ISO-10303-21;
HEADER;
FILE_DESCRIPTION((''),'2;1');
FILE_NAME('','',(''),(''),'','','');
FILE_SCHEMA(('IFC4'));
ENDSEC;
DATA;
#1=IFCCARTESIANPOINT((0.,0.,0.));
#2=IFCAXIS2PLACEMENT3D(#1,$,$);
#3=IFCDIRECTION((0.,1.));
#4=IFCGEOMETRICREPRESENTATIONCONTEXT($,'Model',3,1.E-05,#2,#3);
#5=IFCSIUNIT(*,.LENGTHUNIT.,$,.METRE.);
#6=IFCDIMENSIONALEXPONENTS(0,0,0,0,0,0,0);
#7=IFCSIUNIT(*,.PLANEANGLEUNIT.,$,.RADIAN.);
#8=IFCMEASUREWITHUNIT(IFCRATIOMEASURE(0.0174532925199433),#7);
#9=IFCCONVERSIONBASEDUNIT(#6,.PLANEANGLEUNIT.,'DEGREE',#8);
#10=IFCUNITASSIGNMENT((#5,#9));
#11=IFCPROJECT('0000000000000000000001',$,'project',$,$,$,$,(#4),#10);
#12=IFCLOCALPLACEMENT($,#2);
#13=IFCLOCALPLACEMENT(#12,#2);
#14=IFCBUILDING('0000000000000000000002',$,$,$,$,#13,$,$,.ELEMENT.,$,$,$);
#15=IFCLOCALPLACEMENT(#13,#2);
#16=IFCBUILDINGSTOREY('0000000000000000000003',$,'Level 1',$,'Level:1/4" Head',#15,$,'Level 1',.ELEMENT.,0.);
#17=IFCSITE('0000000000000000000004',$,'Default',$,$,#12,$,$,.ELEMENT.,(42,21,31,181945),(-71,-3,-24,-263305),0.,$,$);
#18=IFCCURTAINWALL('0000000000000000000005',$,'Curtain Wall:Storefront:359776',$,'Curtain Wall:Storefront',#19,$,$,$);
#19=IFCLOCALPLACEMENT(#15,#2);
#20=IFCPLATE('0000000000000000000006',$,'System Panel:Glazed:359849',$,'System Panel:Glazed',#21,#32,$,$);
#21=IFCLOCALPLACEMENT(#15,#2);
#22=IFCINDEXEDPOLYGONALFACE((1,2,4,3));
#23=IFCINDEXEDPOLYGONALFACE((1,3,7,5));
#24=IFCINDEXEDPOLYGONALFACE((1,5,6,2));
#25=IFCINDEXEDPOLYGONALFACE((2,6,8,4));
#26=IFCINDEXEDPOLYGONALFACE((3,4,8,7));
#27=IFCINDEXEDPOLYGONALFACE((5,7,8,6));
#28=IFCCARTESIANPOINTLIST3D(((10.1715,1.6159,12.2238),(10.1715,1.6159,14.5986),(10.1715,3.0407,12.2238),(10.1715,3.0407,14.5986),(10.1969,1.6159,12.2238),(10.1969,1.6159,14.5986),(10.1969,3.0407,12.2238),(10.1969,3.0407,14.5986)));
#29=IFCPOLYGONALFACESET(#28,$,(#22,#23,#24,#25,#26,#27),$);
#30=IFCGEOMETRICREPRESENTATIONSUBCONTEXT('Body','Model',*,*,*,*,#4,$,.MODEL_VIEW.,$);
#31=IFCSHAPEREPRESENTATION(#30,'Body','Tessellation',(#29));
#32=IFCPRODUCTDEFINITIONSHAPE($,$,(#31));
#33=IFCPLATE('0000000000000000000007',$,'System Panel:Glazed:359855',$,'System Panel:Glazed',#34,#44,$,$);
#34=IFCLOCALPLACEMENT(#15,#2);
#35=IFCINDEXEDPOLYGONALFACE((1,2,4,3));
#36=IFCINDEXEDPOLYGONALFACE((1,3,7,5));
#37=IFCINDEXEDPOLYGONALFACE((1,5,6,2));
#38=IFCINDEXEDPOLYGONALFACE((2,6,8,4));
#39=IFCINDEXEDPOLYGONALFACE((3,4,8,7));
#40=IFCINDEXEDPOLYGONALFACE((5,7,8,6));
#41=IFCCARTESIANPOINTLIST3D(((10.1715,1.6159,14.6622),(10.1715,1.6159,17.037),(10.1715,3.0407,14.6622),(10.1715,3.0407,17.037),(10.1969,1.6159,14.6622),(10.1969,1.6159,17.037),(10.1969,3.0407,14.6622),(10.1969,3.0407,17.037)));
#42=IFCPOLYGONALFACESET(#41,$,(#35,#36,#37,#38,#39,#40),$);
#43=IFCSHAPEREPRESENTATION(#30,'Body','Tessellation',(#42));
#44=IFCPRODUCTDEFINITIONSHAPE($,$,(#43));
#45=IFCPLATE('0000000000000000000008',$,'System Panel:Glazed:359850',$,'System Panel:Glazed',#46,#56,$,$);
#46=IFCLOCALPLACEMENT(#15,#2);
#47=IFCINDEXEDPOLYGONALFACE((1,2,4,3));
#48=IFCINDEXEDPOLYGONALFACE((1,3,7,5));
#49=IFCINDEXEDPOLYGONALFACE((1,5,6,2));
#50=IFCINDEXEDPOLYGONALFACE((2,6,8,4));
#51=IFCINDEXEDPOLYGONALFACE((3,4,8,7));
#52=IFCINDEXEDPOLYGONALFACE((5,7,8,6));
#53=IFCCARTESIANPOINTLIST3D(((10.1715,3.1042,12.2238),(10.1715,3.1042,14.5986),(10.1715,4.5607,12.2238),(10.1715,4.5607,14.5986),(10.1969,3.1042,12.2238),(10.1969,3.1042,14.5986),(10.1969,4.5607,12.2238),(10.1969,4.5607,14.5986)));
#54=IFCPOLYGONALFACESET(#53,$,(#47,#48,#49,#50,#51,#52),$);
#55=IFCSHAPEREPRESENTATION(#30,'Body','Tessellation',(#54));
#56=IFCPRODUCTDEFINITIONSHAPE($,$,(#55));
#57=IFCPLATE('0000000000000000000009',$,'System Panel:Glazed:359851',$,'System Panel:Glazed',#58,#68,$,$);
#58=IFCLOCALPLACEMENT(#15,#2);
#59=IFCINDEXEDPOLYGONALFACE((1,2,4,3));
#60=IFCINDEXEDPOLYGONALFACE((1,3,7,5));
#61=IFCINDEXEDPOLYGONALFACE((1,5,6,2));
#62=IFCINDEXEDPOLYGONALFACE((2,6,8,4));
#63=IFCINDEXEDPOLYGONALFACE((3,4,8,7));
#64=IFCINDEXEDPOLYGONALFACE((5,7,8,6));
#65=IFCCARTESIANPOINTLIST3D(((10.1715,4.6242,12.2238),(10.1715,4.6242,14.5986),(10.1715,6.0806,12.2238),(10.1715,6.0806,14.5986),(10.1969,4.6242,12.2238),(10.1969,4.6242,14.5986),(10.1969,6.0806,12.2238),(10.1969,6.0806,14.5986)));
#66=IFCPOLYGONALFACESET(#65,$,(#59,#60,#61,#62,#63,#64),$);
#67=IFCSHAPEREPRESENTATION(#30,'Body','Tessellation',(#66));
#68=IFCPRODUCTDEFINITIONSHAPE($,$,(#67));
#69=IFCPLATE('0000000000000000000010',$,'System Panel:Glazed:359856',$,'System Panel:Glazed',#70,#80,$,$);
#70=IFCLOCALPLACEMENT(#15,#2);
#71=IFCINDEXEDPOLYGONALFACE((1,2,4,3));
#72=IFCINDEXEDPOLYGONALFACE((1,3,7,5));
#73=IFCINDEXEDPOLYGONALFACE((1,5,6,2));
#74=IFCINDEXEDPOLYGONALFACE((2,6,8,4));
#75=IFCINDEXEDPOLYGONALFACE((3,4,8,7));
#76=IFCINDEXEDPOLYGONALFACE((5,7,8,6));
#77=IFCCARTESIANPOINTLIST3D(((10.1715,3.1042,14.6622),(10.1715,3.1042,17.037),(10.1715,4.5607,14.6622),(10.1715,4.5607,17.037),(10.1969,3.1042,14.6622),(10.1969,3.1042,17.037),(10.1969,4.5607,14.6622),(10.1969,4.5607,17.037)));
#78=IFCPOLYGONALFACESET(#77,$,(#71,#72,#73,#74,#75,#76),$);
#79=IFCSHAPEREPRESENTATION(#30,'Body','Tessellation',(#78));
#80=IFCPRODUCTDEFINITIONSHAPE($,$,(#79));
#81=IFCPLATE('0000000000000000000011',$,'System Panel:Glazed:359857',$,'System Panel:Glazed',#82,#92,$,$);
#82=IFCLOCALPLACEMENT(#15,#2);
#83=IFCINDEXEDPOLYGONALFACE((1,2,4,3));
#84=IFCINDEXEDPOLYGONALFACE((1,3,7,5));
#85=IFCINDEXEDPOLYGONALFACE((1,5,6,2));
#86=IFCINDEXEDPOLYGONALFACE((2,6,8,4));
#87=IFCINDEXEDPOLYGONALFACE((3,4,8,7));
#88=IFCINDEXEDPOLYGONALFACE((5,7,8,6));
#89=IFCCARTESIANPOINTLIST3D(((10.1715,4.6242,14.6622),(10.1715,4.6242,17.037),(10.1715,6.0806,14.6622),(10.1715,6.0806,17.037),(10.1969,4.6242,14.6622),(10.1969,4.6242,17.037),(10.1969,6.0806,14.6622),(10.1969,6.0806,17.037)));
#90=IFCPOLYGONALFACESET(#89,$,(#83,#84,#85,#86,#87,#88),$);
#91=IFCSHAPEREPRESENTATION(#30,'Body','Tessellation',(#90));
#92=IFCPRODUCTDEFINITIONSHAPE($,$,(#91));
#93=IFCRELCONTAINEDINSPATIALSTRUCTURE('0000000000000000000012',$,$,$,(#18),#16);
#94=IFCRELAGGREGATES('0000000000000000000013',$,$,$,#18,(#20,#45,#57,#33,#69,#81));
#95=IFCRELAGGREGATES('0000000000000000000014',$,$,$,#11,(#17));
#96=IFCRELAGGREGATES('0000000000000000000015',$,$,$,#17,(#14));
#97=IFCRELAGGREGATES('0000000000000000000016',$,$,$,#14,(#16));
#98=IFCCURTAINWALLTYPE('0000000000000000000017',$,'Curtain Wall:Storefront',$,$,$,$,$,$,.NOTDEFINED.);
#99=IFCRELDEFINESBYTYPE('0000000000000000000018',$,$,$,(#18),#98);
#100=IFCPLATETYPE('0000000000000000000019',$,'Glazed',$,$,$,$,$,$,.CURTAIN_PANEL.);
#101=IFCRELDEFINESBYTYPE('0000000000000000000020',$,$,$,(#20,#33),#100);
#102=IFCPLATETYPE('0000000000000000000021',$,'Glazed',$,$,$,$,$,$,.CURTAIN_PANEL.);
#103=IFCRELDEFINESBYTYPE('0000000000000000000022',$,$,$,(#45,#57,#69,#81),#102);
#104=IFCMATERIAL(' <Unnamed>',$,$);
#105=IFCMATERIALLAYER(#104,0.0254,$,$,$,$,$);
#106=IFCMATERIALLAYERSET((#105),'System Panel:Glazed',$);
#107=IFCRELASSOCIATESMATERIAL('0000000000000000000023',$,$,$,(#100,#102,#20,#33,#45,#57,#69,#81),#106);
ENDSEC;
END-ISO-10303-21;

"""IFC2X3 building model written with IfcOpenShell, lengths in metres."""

from ifc_helpers import new_model, entity, si_unit, converted_unit, direction, frame, frame_2d, origin, origin_2d_with_axis, place, context, subcontext, project, spatial, rectangle, extrude, source, transform, mapped, material, layer, layer_set, layer_usage, type_object, type_shapes, element, aggregate, save


model = new_model("IFC2X3")

# Units and contexts
model_context = context("Model", 3, precision=1e-05, world=origin(), true_north=direction((0.0, 1.0)))
body_context = subcontext(model_context, "Body", "Model", "MODEL_VIEW")
ifc_project = project(units=[si_unit("LENGTHUNIT", "METRE"), converted_unit("PLANEANGLEUNIT", "DEGREE", entity("IfcRatioMeasure", 0.0174532925199433), si_unit("PLANEANGLEUNIT", "RADIAN"), dimensions=[0, 0, 0, 0, 0, 0, 0])], contexts=[model_context])

# Site, building, storey
site_placement = place(None, origin())
site = spatial("IfcSite", under=ifc_project, at=site_placement, Name="Default", CompositionType="ELEMENT", RefLatitude=(42, 21, 31, 181945), RefLongitude=(-71, -3, -24, -263305), RefElevation=0.0)
building_placement = place(site_placement, origin())
building = spatial("IfcBuilding", under=site, at=building_placement, CompositionType="ELEMENT")
storey_placement = place(building_placement, origin())
storey = spatial("IfcBuildingStorey", under=building, at=storey_placement, Name="Level 1", ObjectType="Level:1/4\" Head", LongName="Level 1", CompositionType="ELEMENT", Elevation=0.0)

# Curtain wall, plates
curtain_wall_type = type_object("IfcCurtainWallType", Name="Curtain Wall:Storefront", PredefinedType="NOTDEFINED")
curtain_wall_placement = place(storey_placement, origin())
curtain_wall = element("IfcCurtainWall", 1, at=curtain_wall_placement, inside=storey, type_object=curtain_wall_type, Name="Curtain Wall:Storefront:359776", ObjectType="Curtain Wall:Storefront")
ifc_material_1 = material(Name=" <Unnamed>")
ifc_layer = layer(ifc_material_1, 0.0254)
ifc_layer_set = layer_set([ifc_layer], Name="System Panel:Glazed")
ifc_layer_usage_1 = layer_usage(ifc_layer_set, "AXIS3", "POSITIVE", 0.1042)
plate_type_1 = type_object("IfcPlateType", Name="Glazed", PredefinedType="CURTAIN_PANEL", material=ifc_layer_set)
shared_shape_1 = source(origin(), body_context, "Body", "SweptSolid", [
    extrude(rectangle(XDim=0.0254, YDim=1.4248, at=frame_2d((0.0, 0.0), x_axis=(1.0, 0.0))), frame((0.7124, 0.0127, 0.0), z_axis=(0.0, 0.0, 1.0), x_axis=(0.0, 1.0, 0.0)), (0.0, 0.0, 1.0), 2.3749),
])
type_shapes(plate_type_1, [shared_shape_1])
plate_1_placement = place(curtain_wall_placement, frame((10.1969, 1.6159, 12.2238), z_axis=(0.0, 0.0, 1.0), x_axis=(0.0, 1.0, 0.0)))
plate_1 = element("IfcPlate", 2, at=plate_1_placement, type_object=plate_type_1, material=ifc_layer_usage_1, Name="System Panel:Glazed:359849", ObjectType="System Panel:Glazed", context=body_context, shape_type="MappedRepresentation", body=[
    mapped(shared_shape_1, transform((0.0, 0.0, 0.0), scale=1.0)),
])
ifc_layer_usage_2 = layer_usage(ifc_layer_set, "AXIS3", "POSITIVE", 0.1042)
plate_2_placement = place(curtain_wall_placement, frame((10.1969, 1.6159, 14.6622), z_axis=(0.0, 0.0, 1.0), x_axis=(0.0, 1.0, 0.0)))
plate_2 = element("IfcPlate", 3, at=plate_2_placement, type_object=plate_type_1, material=ifc_layer_usage_2, Name="System Panel:Glazed:359855", ObjectType="System Panel:Glazed", context=body_context, shape_type="MappedRepresentation", body=[
    mapped(shared_shape_1, transform((0.0, 0.0, 0.0), scale=1.0)),
])
ifc_layer_usage_3 = layer_usage(ifc_layer_set, "AXIS3", "POSITIVE", 0.1042)
plate_type_2 = type_object("IfcPlateType", Name="Glazed", PredefinedType="CURTAIN_PANEL", material=ifc_layer_set)
shared_shape_2 = source(origin(), body_context, "Body", "SweptSolid", [
    extrude(rectangle(XDim=0.0254, YDim=1.4565, at=origin_2d_with_axis()), frame((0.7282, 0.0127, 0.0), z_axis=(0.0, 0.0, 1.0), x_axis=(0.0, 1.0, 0.0)), (0.0, 0.0, 1.0), 2.3749),
])
type_shapes(plate_type_2, [shared_shape_2])
plate_3_placement = place(curtain_wall_placement, frame((10.1969, 3.1042, 12.2238), z_axis=(0.0, 0.0, 1.0), x_axis=(0.0, 1.0, 0.0)))
plate_3 = element("IfcPlate", 4, at=plate_3_placement, type_object=plate_type_2, material=ifc_layer_usage_3, Name="System Panel:Glazed:359850", ObjectType="System Panel:Glazed", context=body_context, shape_type="MappedRepresentation", body=[
    mapped(shared_shape_2, transform((0.0, 0.0, 0.0), scale=1.0)),
])
ifc_layer_usage_4 = layer_usage(ifc_layer_set, "AXIS3", "POSITIVE", 0.1042)
plate_4_placement = place(curtain_wall_placement, frame((10.1969, 4.6242, 12.2238), z_axis=(0.0, 0.0, 1.0), x_axis=(0.0, 1.0, 0.0)))
plate_4 = element("IfcPlate", 5, at=plate_4_placement, type_object=plate_type_2, material=ifc_layer_usage_4, Name="System Panel:Glazed:359851", ObjectType="System Panel:Glazed", context=body_context, shape_type="MappedRepresentation", body=[
    mapped(shared_shape_2, transform((0.0, 0.0, 0.0), scale=1.0)),
])
ifc_layer_usage_5 = layer_usage(ifc_layer_set, "AXIS3", "POSITIVE", 0.1042)
plate_5_placement = place(curtain_wall_placement, frame((10.1969, 3.1042, 14.6622), z_axis=(0.0, 0.0, 1.0), x_axis=(0.0, 1.0, 0.0)))
plate_5 = element("IfcPlate", 6, at=plate_5_placement, type_object=plate_type_2, material=ifc_layer_usage_5, Name="System Panel:Glazed:359856", ObjectType="System Panel:Glazed", context=body_context, shape_type="MappedRepresentation", body=[
    mapped(shared_shape_2, transform((0.0, 0.0, 0.0), scale=1.0)),
])
ifc_layer_usage_6 = layer_usage(ifc_layer_set, "AXIS3", "POSITIVE", 0.1042)
plate_6_placement = place(curtain_wall_placement, frame((10.1969, 4.6242, 14.6622), z_axis=(0.0, 0.0, 1.0), x_axis=(0.0, 1.0, 0.0)))
plate_6 = element("IfcPlate", 7, at=plate_6_placement, type_object=plate_type_2, material=ifc_layer_usage_6, Name="System Panel:Glazed:359857", ObjectType="System Panel:Glazed", context=body_context, shape_type="MappedRepresentation", body=[
    mapped(shared_shape_2, transform((0.0, 0.0, 0.0), scale=1.0)),
])
aggregate(curtain_wall, [plate_1, plate_3, plate_4, plate_2, plate_5, plate_6])

save(model, "model.ifc")
